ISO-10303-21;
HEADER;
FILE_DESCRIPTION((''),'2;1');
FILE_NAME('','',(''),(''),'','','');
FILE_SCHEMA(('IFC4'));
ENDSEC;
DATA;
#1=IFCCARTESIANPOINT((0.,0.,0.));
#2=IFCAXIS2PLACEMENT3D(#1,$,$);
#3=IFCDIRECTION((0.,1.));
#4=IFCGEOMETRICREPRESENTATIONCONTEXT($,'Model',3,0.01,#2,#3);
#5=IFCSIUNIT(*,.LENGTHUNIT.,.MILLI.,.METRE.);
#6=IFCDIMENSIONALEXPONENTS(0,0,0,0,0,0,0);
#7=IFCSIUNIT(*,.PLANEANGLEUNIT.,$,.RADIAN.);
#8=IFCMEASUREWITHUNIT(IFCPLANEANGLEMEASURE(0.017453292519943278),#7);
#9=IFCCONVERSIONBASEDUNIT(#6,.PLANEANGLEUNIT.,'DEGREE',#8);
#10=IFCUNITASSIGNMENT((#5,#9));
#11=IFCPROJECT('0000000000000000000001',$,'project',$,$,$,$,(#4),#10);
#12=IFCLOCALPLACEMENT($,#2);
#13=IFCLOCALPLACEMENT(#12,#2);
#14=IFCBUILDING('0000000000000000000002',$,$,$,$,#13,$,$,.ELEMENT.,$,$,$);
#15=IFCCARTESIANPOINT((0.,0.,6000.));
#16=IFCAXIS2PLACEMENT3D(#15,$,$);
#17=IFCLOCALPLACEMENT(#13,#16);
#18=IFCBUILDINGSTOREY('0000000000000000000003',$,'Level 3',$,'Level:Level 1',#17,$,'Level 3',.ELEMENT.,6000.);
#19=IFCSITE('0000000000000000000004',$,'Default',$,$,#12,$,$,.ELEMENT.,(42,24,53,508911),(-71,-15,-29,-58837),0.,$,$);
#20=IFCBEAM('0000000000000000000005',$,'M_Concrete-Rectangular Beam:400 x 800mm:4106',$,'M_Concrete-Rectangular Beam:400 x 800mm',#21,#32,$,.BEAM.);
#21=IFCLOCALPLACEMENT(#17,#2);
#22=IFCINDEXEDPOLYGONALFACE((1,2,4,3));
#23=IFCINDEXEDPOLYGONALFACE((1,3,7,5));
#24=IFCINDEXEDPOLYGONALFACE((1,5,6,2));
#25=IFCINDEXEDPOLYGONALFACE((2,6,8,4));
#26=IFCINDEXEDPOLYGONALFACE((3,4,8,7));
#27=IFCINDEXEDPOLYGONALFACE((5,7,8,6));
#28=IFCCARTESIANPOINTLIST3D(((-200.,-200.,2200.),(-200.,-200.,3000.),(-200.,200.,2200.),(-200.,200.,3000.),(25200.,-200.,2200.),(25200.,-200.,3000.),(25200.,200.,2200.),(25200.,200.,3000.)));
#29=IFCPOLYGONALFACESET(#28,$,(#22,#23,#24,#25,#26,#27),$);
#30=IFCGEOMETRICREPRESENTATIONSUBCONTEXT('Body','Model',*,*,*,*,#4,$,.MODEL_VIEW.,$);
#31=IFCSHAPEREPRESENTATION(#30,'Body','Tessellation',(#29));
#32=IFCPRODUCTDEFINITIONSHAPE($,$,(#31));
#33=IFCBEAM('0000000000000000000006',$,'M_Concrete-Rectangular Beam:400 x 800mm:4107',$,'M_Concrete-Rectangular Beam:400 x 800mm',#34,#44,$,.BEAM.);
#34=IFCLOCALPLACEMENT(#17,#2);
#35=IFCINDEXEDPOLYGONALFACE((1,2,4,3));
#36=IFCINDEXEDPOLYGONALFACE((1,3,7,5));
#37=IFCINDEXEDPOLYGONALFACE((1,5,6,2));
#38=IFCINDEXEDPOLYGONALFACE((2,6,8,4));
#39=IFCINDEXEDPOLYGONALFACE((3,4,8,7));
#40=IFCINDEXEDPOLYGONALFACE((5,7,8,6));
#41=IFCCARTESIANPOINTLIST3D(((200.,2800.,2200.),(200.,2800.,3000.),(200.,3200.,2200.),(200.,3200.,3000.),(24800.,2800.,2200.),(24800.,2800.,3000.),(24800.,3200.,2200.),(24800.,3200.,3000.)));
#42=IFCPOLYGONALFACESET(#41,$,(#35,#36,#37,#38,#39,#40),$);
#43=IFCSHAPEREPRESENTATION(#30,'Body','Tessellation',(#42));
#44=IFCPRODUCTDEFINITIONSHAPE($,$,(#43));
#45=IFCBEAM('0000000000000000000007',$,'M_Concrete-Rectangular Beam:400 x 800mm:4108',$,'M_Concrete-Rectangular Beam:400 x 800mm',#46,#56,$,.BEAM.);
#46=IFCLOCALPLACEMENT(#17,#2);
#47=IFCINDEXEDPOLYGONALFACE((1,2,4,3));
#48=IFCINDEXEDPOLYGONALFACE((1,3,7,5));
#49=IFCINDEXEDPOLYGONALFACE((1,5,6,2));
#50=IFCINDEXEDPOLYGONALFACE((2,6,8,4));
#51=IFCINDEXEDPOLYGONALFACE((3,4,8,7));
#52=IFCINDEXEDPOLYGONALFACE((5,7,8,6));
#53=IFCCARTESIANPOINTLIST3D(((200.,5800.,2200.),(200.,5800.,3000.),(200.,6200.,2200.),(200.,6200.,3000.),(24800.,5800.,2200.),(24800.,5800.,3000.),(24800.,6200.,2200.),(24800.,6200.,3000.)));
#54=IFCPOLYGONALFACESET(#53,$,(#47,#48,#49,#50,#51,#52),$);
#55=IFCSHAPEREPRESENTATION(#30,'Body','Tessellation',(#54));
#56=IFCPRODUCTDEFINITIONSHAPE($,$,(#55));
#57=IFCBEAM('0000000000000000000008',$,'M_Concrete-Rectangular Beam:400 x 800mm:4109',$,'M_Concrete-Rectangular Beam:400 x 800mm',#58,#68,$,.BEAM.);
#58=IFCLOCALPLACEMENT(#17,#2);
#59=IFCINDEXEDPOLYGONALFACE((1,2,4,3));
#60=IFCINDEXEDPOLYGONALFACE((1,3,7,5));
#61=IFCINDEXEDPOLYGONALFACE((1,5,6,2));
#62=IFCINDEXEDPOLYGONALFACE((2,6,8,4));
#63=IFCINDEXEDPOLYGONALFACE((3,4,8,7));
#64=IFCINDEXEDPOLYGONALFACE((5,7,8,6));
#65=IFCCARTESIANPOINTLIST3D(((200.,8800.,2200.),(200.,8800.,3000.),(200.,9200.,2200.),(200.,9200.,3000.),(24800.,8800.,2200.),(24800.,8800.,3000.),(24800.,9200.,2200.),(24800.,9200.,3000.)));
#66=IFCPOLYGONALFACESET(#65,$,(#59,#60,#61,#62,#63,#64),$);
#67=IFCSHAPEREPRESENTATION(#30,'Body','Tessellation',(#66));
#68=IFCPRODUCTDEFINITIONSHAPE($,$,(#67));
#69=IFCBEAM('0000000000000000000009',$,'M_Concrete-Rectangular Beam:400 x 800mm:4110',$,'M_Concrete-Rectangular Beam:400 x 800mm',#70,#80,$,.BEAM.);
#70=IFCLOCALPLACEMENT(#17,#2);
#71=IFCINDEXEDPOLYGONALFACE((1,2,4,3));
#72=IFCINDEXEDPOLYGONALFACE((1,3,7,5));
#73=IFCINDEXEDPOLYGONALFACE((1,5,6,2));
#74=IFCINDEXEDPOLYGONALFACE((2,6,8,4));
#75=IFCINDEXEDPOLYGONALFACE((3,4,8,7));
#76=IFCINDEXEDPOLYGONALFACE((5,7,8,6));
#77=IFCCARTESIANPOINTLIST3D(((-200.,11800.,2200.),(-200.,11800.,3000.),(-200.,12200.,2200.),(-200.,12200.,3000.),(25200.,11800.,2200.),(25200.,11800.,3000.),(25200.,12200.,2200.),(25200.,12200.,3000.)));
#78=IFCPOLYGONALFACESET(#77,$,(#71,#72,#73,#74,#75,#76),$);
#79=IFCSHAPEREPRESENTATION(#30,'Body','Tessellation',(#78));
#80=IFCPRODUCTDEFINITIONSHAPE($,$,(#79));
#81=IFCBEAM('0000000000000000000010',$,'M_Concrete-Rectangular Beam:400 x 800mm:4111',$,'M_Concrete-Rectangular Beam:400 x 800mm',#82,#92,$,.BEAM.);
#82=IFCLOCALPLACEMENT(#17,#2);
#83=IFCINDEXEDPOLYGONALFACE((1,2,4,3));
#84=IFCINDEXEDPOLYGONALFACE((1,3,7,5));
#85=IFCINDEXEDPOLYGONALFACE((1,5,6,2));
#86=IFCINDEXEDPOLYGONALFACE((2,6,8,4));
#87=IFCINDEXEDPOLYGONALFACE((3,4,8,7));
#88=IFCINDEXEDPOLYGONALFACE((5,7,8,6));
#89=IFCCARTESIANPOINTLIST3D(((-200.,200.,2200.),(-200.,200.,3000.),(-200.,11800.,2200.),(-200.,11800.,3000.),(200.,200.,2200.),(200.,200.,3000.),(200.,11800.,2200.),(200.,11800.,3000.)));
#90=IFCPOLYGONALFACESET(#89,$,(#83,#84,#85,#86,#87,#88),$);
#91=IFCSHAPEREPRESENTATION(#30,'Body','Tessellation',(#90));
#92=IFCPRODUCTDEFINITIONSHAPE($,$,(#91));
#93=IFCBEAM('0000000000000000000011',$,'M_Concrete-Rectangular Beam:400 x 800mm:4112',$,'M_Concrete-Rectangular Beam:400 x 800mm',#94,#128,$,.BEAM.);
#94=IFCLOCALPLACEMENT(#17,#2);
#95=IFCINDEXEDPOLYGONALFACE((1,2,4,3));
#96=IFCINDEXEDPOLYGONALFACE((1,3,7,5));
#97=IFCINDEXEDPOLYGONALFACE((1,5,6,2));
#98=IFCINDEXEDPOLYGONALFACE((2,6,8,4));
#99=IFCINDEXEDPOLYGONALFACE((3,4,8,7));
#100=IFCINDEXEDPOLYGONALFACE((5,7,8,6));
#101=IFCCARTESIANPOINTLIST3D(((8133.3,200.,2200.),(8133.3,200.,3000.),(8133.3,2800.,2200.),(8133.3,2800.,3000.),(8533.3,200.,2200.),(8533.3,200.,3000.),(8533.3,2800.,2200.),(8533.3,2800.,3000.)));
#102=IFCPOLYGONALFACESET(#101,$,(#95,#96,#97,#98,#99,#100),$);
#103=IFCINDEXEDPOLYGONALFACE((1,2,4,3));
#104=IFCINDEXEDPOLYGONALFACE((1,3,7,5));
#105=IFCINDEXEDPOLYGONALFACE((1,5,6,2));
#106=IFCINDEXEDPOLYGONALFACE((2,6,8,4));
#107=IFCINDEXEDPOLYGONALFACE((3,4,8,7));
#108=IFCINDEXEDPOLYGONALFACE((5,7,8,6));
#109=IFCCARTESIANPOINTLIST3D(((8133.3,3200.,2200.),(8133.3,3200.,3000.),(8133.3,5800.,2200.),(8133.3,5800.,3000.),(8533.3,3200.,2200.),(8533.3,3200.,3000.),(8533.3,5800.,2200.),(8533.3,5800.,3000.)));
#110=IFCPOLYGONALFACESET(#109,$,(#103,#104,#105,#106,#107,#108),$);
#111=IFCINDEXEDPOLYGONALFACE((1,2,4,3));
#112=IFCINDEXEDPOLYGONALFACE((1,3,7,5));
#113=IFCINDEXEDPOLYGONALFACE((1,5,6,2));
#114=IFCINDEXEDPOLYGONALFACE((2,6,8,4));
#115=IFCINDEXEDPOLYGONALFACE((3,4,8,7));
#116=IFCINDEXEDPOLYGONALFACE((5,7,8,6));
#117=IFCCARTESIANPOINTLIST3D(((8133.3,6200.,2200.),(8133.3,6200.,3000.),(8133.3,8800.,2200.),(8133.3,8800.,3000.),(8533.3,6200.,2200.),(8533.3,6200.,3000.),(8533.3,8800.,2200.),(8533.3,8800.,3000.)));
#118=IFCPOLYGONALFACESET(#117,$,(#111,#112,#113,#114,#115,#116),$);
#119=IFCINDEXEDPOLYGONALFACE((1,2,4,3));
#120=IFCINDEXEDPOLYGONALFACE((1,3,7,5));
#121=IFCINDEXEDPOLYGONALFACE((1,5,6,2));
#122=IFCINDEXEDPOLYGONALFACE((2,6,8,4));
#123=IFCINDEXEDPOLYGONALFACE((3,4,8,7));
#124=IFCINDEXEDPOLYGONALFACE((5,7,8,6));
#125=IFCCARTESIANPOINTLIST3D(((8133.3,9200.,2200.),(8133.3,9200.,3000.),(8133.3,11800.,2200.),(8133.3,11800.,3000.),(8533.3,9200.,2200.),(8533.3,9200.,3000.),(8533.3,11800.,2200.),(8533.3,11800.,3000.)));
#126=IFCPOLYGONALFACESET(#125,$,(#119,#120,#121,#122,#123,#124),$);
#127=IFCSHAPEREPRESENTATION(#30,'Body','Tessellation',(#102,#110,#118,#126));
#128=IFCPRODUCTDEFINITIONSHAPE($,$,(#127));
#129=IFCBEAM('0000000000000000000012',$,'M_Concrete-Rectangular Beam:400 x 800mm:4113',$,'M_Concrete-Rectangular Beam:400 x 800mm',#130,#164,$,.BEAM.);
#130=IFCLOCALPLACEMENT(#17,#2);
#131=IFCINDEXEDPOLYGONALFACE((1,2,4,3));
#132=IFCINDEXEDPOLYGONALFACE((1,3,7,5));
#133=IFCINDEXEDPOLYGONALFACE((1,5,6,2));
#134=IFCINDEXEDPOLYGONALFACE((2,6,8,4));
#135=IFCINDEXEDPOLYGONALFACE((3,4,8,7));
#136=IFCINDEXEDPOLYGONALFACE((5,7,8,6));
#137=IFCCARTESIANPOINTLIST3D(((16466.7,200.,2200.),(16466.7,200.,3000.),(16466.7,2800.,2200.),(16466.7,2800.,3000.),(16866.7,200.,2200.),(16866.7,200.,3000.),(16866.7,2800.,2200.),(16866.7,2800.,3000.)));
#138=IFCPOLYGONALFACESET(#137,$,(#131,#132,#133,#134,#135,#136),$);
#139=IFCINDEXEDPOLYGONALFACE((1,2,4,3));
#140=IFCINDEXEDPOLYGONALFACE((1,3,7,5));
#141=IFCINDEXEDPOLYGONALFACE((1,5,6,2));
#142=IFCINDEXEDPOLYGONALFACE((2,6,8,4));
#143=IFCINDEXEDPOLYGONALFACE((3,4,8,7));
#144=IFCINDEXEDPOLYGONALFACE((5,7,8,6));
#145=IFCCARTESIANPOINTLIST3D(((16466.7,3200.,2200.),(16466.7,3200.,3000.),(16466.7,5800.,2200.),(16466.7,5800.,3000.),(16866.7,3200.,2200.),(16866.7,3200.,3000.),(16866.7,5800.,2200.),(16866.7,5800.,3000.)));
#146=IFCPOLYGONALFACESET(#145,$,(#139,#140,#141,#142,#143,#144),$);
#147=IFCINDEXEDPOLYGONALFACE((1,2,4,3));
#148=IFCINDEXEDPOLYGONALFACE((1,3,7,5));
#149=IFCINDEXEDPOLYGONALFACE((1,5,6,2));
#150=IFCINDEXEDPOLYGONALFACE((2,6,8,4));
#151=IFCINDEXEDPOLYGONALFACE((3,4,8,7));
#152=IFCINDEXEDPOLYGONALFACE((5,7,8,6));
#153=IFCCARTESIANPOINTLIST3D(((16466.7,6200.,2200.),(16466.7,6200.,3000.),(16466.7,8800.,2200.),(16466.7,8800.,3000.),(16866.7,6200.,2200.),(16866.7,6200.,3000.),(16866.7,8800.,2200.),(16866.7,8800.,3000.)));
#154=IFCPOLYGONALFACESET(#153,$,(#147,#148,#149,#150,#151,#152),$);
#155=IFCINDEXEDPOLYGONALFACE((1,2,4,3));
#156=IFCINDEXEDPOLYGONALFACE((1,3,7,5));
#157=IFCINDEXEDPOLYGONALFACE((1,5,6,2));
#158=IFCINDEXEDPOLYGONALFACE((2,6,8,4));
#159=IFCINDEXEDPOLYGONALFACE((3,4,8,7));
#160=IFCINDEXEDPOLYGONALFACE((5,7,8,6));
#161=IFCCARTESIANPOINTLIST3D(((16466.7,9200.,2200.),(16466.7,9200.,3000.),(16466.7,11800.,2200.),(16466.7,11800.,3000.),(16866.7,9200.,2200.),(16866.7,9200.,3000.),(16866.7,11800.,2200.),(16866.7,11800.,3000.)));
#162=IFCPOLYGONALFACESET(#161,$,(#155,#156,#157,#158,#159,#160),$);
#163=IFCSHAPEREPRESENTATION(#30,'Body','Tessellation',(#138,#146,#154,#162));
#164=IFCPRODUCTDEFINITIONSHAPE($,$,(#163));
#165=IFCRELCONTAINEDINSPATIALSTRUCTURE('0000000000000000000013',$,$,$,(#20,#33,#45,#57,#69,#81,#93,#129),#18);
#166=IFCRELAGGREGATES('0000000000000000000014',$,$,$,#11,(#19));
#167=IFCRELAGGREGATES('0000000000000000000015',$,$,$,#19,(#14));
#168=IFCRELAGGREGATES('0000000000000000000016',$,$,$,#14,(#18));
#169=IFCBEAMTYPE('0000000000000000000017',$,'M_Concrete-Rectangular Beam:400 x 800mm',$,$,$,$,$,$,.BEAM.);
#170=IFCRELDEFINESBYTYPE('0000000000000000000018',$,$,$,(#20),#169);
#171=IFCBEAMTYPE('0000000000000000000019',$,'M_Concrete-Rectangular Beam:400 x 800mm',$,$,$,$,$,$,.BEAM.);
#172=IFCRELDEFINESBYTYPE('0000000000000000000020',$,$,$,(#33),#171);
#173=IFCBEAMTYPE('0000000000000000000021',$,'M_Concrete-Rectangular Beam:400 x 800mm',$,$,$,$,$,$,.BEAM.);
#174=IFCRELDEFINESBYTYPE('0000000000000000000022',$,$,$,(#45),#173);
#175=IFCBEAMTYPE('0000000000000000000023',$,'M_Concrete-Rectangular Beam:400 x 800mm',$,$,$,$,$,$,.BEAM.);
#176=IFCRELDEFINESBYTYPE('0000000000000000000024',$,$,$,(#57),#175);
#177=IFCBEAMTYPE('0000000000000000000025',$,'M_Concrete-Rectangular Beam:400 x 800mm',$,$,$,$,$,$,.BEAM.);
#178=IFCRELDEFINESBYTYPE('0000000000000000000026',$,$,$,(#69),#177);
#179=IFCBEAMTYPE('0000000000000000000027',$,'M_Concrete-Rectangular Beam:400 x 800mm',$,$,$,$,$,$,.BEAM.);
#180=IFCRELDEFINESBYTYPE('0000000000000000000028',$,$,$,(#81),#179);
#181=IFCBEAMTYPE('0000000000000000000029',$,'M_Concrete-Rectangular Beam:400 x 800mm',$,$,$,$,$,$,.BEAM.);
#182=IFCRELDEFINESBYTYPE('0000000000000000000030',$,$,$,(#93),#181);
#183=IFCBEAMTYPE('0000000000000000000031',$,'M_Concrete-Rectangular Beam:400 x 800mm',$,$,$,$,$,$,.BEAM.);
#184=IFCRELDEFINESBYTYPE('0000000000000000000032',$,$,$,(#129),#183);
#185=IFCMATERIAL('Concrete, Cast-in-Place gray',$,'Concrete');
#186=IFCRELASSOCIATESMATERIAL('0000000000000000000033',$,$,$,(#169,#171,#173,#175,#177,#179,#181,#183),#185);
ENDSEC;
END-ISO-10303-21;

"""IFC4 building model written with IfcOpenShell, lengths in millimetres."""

from ifc_helpers import new_model, entity, si_unit, converted_unit, direction, frame, frame_2d, origin, origin_2d_with_axis, place, context, subcontext, project, spatial, rectangle, extrude, source, transform, mapped, material, material_profile, profile_set, type_object, type_shapes, element, save


model = new_model("IFC4")

# Units and contexts
model_context = context("Model", 3, precision=0.01, world=origin(), true_north=direction((0.0, 1.0)))
body_context = subcontext(model_context, "Body", "Model", "MODEL_VIEW")
ifc_project = project(units=[si_unit("LENGTHUNIT", "METRE", prefix="MILLI"), converted_unit("PLANEANGLEUNIT", "DEGREE", entity("IfcPlaneAngleMeasure", 0.017453292519943278), si_unit("PLANEANGLEUNIT", "RADIAN"), dimensions=[0, 0, 0, 0, 0, 0, 0])], contexts=[model_context])

# Site, building, storey
site_placement = place(None, origin())
site = spatial("IfcSite", under=ifc_project, at=site_placement, Name="Default", CompositionType="ELEMENT", RefLatitude=(42, 24, 53, 508911), RefLongitude=(-71, -15, -29, -58837), RefElevation=0.0)
building_placement = place(site_placement, origin())
building = spatial("IfcBuilding", under=site, at=building_placement, CompositionType="ELEMENT")
storey_placement = place(building_placement, frame((0.0, 0.0, 6000.0)))
storey = spatial("IfcBuildingStorey", under=building, at=storey_placement, Name="Level 3", ObjectType="Level:Level 1", LongName="Level 3", CompositionType="ELEMENT", Elevation=6000.0)

# Beams
ifc_material_1 = material(Name="Concrete, Cast-in-Place gray", Category="Concrete")
ifc_material_profile = material_profile(ifc_material_1, rectangle(XDim=800.0, YDim=400.0, at=origin_2d_with_axis()), Name="400 x 800mm")
ifc_profile_set = profile_set([ifc_material_profile], Name="400 x 800mm")
beam_type_1 = type_object("IfcBeamType", Name="M_Concrete-Rectangular Beam:400 x 800mm", PredefinedType="BEAM", material=ifc_profile_set)
shared_shape_1 = source(origin(), body_context, "Body", "SweptSolid", [
    extrude(rectangle(XDim=800.0, YDim=400.0, at=origin_2d_with_axis()), frame((-200.0, 0.0, 8600.0), z_axis=(1.0, 0.0, 0.0), x_axis=(0.0, 0.0, -1.0)), (0.0, 0.0, 1.0), 25400.0),
])
type_shapes(beam_type_1, [shared_shape_1])
beam_1_placement = place(storey_placement, frame((0.0, 0.0, -6000.0)))
element("IfcBeam", 1, at=beam_1_placement, inside=storey, type_object=beam_type_1, Name="M_Concrete-Rectangular Beam:400 x 800mm:4106", ObjectType="M_Concrete-Rectangular Beam:400 x 800mm", PredefinedType="BEAM", context=body_context, shape_type="MappedRepresentation", body=[
    mapped(shared_shape_1, transform((0.0, 0.0, 0.0), scale=1.0)),
])
beam_type_2 = type_object("IfcBeamType", Name="M_Concrete-Rectangular Beam:400 x 800mm", PredefinedType="BEAM", material=ifc_profile_set)
shared_shape_2 = source(origin(), body_context, "Body", "SweptSolid", [
    extrude(rectangle(XDim=800.0, YDim=400.0, at=origin_2d_with_axis()), frame((200.0, 3000.0, 8600.0), z_axis=(1.0, 0.0, 0.0), x_axis=(0.0, 0.0, -1.0)), (0.0, 0.0, 1.0), 24600.0),
])
type_shapes(beam_type_2, [shared_shape_2])
beam_2_placement = place(storey_placement, frame((0.0, 0.0, -6000.0)))
element("IfcBeam", 2, at=beam_2_placement, inside=storey, type_object=beam_type_2, Name="M_Concrete-Rectangular Beam:400 x 800mm:4107", ObjectType="M_Concrete-Rectangular Beam:400 x 800mm", PredefinedType="BEAM", context=body_context, shape_type="MappedRepresentation", body=[
    mapped(shared_shape_2, transform((0.0, 0.0, 0.0), scale=1.0)),
])
beam_type_3 = type_object("IfcBeamType", Name="M_Concrete-Rectangular Beam:400 x 800mm", PredefinedType="BEAM", material=ifc_profile_set)
shared_shape_3 = source(origin(), body_context, "Body", "SweptSolid", [
    extrude(rectangle(XDim=800.0, YDim=400.0, at=frame_2d((0.0, 0.0), x_axis=(1.0, 0.0))), frame((200.0, 6000.0, 8600.0), z_axis=(1.0, 0.0, 0.0), x_axis=(0.0, 0.0, -1.0)), (0.0, 0.0, 1.0), 24600.0),
])
type_shapes(beam_type_3, [shared_shape_3])
beam_3_placement = place(storey_placement, frame((0.0, 0.0, -6000.0)))
element("IfcBeam", 3, at=beam_3_placement, inside=storey, type_object=beam_type_3, Name="M_Concrete-Rectangular Beam:400 x 800mm:4108", ObjectType="M_Concrete-Rectangular Beam:400 x 800mm", PredefinedType="BEAM", context=body_context, shape_type="MappedRepresentation", body=[
    mapped(shared_shape_3, transform((0.0, 0.0, 0.0), scale=1.0)),
])
beam_type_4 = type_object("IfcBeamType", Name="M_Concrete-Rectangular Beam:400 x 800mm", PredefinedType="BEAM", material=ifc_profile_set)
shared_shape_4 = source(origin(), body_context, "Body", "SweptSolid", [
    extrude(rectangle(XDim=800.0, YDim=400.0, at=frame_2d((0.0, 0.0), x_axis=(1.0, 0.0))), frame((200.0, 9000.0, 8600.0), z_axis=(1.0, 0.0, 0.0), x_axis=(0.0, 0.0, -1.0)), (0.0, 0.0, 1.0), 24600.0),
])
type_shapes(beam_type_4, [shared_shape_4])
beam_4_placement = place(storey_placement, frame((0.0, 0.0, -6000.0)))
element("IfcBeam", 4, at=beam_4_placement, inside=storey, type_object=beam_type_4, Name="M_Concrete-Rectangular Beam:400 x 800mm:4109", ObjectType="M_Concrete-Rectangular Beam:400 x 800mm", PredefinedType="BEAM", context=body_context, shape_type="MappedRepresentation", body=[
    mapped(shared_shape_4, transform((0.0, 0.0, 0.0), scale=1.0)),
])
beam_type_5 = type_object("IfcBeamType", Name="M_Concrete-Rectangular Beam:400 x 800mm", PredefinedType="BEAM", material=ifc_profile_set)
shared_shape_5 = source(origin(), body_context, "Body", "SweptSolid", [
    extrude(rectangle(XDim=800.0, YDim=400.0, at=frame_2d((0.0, 0.0), x_axis=(1.0, 0.0))), frame((-200.0, 12000.0, 8600.0), z_axis=(1.0, 0.0, 0.0), x_axis=(0.0, 0.0, -1.0)), (0.0, 0.0, 1.0), 25400.0),
])
type_shapes(beam_type_5, [shared_shape_5])
beam_5_placement = place(storey_placement, frame((0.0, 0.0, -6000.0)))
element("IfcBeam", 5, at=beam_5_placement, inside=storey, type_object=beam_type_5, Name="M_Concrete-Rectangular Beam:400 x 800mm:4110", ObjectType="M_Concrete-Rectangular Beam:400 x 800mm", PredefinedType="BEAM", context=body_context, shape_type="MappedRepresentation", body=[
    mapped(shared_shape_5, transform((0.0, 0.0, 0.0), scale=1.0)),
])
beam_type_6 = type_object("IfcBeamType", Name="M_Concrete-Rectangular Beam:400 x 800mm", PredefinedType="BEAM", material=ifc_profile_set)
shared_shape_6 = source(origin(), body_context, "Body", "SweptSolid", [
    extrude(rectangle(XDim=800.0, YDim=400.0, at=frame_2d((0.0, 0.0), x_axis=(0.0, 1.0))), frame((0.0, 200.0, 8600.0), z_axis=(0.0, 1.0, 0.0), x_axis=(-1.0, 0.0, 0.0)), (0.0, 0.0, 1.0), 11600.0),
])
type_shapes(beam_type_6, [shared_shape_6])
beam_6_placement = place(storey_placement, frame((0.0, 0.0, -6000.0)))
element("IfcBeam", 6, at=beam_6_placement, inside=storey, type_object=beam_type_6, Name="M_Concrete-Rectangular Beam:400 x 800mm:4111", ObjectType="M_Concrete-Rectangular Beam:400 x 800mm", PredefinedType="BEAM", context=body_context, shape_type="MappedRepresentation", body=[
    mapped(shared_shape_6, transform((0.0, 0.0, 0.0), scale=1.0)),
])
beam_type_7 = type_object("IfcBeamType", Name="M_Concrete-Rectangular Beam:400 x 800mm", PredefinedType="BEAM", material=ifc_profile_set)
shared_shape_7 = source(origin(), body_context, "Body", "SweptSolid", [
    extrude(rectangle(XDim=800.0, YDim=400.0, at=frame_2d((0.0, 0.0), x_axis=(0.0, 1.0))), frame((8333.3, 200.0, 8600.0), z_axis=(0.0, 1.0, 0.0), x_axis=(-1.0, 0.0, 0.0)), (0.0, 0.0, 1.0), 2600.0),
    extrude(rectangle(XDim=800.0, YDim=400.0, at=frame_2d((0.0, 0.0), x_axis=(0.0, 1.0))), frame((8333.3, 3200.0, 8600.0), z_axis=(0.0, 1.0, 0.0), x_axis=(-1.0, 0.0, 0.0)), (0.0, 0.0, 1.0), 2600.0),
    extrude(rectangle(XDim=800.0, YDim=400.0, at=frame_2d((0.0, 0.0), x_axis=(0.0, 1.0))), frame((8333.3, 6200.0, 8600.0), z_axis=(0.0, 1.0, 0.0), x_axis=(-1.0, 0.0, 0.0)), (0.0, 0.0, 1.0), 2600.0),
    extrude(rectangle(XDim=800.0, YDim=400.0, at=frame_2d((0.0, 0.0), x_axis=(0.0, 1.0))), frame((8333.3, 9200.0, 8600.0), z_axis=(0.0, 1.0, 0.0), x_axis=(-1.0, 0.0, 0.0)), (0.0, 0.0, 1.0), 2600.0),
])
type_shapes(beam_type_7, [shared_shape_7])
beam_7_placement = place(storey_placement, frame((0.0, 0.0, -6000.0)))
element("IfcBeam", 7, at=beam_7_placement, inside=storey, type_object=beam_type_7, Name="M_Concrete-Rectangular Beam:400 x 800mm:4112", ObjectType="M_Concrete-Rectangular Beam:400 x 800mm", PredefinedType="BEAM", context=body_context, shape_type="MappedRepresentation", body=[
    mapped(shared_shape_7, transform((0.0, 0.0, 0.0), scale=1.0)),
])
beam_type_8 = type_object("IfcBeamType", Name="M_Concrete-Rectangular Beam:400 x 800mm", PredefinedType="BEAM", material=ifc_profile_set)
shared_shape_8 = source(origin(), body_context, "Body", "SweptSolid", [
    extrude(rectangle(XDim=800.0, YDim=400.0, at=frame_2d((0.0, 0.0), x_axis=(0.0, 1.0))), frame((16666.7, 200.0, 8600.0), z_axis=(0.0, 1.0, 0.0), x_axis=(-1.0, 0.0, 0.0)), (0.0, 0.0, 1.0), 2600.0),
    extrude(rectangle(XDim=800.0, YDim=400.0, at=frame_2d((0.0, 0.0), x_axis=(0.0, 1.0))), frame((16666.7, 3200.0, 8600.0), z_axis=(0.0, 1.0, 0.0), x_axis=(-1.0, 0.0, 0.0)), (0.0, 0.0, 1.0), 2600.0),
    extrude(rectangle(XDim=800.0, YDim=400.0, at=frame_2d((0.0, 0.0), x_axis=(0.0, 1.0))), frame((16666.7, 6200.0, 8600.0), z_axis=(0.0, 1.0, 0.0), x_axis=(-1.0, 0.0, 0.0)), (0.0, 0.0, 1.0), 2600.0),
    extrude(rectangle(XDim=800.0, YDim=400.0, at=frame_2d((0.0, 0.0), x_axis=(0.0, 1.0))), frame((16666.7, 9200.0, 8600.0), z_axis=(0.0, 1.0, 0.0), x_axis=(-1.0, 0.0, 0.0)), (0.0, 0.0, 1.0), 2600.0),
])
type_shapes(beam_type_8, [shared_shape_8])
beam_8_placement = place(storey_placement, frame((0.0, 0.0, -6000.0)))
element("IfcBeam", 8, at=beam_8_placement, inside=storey, type_object=beam_type_8, Name="M_Concrete-Rectangular Beam:400 x 800mm:4113", ObjectType="M_Concrete-Rectangular Beam:400 x 800mm", PredefinedType="BEAM", context=body_context, shape_type="MappedRepresentation", body=[
    mapped(shared_shape_8, transform((0.0, 0.0, 0.0), scale=1.0)),
])

save(model, "model.ifc")
